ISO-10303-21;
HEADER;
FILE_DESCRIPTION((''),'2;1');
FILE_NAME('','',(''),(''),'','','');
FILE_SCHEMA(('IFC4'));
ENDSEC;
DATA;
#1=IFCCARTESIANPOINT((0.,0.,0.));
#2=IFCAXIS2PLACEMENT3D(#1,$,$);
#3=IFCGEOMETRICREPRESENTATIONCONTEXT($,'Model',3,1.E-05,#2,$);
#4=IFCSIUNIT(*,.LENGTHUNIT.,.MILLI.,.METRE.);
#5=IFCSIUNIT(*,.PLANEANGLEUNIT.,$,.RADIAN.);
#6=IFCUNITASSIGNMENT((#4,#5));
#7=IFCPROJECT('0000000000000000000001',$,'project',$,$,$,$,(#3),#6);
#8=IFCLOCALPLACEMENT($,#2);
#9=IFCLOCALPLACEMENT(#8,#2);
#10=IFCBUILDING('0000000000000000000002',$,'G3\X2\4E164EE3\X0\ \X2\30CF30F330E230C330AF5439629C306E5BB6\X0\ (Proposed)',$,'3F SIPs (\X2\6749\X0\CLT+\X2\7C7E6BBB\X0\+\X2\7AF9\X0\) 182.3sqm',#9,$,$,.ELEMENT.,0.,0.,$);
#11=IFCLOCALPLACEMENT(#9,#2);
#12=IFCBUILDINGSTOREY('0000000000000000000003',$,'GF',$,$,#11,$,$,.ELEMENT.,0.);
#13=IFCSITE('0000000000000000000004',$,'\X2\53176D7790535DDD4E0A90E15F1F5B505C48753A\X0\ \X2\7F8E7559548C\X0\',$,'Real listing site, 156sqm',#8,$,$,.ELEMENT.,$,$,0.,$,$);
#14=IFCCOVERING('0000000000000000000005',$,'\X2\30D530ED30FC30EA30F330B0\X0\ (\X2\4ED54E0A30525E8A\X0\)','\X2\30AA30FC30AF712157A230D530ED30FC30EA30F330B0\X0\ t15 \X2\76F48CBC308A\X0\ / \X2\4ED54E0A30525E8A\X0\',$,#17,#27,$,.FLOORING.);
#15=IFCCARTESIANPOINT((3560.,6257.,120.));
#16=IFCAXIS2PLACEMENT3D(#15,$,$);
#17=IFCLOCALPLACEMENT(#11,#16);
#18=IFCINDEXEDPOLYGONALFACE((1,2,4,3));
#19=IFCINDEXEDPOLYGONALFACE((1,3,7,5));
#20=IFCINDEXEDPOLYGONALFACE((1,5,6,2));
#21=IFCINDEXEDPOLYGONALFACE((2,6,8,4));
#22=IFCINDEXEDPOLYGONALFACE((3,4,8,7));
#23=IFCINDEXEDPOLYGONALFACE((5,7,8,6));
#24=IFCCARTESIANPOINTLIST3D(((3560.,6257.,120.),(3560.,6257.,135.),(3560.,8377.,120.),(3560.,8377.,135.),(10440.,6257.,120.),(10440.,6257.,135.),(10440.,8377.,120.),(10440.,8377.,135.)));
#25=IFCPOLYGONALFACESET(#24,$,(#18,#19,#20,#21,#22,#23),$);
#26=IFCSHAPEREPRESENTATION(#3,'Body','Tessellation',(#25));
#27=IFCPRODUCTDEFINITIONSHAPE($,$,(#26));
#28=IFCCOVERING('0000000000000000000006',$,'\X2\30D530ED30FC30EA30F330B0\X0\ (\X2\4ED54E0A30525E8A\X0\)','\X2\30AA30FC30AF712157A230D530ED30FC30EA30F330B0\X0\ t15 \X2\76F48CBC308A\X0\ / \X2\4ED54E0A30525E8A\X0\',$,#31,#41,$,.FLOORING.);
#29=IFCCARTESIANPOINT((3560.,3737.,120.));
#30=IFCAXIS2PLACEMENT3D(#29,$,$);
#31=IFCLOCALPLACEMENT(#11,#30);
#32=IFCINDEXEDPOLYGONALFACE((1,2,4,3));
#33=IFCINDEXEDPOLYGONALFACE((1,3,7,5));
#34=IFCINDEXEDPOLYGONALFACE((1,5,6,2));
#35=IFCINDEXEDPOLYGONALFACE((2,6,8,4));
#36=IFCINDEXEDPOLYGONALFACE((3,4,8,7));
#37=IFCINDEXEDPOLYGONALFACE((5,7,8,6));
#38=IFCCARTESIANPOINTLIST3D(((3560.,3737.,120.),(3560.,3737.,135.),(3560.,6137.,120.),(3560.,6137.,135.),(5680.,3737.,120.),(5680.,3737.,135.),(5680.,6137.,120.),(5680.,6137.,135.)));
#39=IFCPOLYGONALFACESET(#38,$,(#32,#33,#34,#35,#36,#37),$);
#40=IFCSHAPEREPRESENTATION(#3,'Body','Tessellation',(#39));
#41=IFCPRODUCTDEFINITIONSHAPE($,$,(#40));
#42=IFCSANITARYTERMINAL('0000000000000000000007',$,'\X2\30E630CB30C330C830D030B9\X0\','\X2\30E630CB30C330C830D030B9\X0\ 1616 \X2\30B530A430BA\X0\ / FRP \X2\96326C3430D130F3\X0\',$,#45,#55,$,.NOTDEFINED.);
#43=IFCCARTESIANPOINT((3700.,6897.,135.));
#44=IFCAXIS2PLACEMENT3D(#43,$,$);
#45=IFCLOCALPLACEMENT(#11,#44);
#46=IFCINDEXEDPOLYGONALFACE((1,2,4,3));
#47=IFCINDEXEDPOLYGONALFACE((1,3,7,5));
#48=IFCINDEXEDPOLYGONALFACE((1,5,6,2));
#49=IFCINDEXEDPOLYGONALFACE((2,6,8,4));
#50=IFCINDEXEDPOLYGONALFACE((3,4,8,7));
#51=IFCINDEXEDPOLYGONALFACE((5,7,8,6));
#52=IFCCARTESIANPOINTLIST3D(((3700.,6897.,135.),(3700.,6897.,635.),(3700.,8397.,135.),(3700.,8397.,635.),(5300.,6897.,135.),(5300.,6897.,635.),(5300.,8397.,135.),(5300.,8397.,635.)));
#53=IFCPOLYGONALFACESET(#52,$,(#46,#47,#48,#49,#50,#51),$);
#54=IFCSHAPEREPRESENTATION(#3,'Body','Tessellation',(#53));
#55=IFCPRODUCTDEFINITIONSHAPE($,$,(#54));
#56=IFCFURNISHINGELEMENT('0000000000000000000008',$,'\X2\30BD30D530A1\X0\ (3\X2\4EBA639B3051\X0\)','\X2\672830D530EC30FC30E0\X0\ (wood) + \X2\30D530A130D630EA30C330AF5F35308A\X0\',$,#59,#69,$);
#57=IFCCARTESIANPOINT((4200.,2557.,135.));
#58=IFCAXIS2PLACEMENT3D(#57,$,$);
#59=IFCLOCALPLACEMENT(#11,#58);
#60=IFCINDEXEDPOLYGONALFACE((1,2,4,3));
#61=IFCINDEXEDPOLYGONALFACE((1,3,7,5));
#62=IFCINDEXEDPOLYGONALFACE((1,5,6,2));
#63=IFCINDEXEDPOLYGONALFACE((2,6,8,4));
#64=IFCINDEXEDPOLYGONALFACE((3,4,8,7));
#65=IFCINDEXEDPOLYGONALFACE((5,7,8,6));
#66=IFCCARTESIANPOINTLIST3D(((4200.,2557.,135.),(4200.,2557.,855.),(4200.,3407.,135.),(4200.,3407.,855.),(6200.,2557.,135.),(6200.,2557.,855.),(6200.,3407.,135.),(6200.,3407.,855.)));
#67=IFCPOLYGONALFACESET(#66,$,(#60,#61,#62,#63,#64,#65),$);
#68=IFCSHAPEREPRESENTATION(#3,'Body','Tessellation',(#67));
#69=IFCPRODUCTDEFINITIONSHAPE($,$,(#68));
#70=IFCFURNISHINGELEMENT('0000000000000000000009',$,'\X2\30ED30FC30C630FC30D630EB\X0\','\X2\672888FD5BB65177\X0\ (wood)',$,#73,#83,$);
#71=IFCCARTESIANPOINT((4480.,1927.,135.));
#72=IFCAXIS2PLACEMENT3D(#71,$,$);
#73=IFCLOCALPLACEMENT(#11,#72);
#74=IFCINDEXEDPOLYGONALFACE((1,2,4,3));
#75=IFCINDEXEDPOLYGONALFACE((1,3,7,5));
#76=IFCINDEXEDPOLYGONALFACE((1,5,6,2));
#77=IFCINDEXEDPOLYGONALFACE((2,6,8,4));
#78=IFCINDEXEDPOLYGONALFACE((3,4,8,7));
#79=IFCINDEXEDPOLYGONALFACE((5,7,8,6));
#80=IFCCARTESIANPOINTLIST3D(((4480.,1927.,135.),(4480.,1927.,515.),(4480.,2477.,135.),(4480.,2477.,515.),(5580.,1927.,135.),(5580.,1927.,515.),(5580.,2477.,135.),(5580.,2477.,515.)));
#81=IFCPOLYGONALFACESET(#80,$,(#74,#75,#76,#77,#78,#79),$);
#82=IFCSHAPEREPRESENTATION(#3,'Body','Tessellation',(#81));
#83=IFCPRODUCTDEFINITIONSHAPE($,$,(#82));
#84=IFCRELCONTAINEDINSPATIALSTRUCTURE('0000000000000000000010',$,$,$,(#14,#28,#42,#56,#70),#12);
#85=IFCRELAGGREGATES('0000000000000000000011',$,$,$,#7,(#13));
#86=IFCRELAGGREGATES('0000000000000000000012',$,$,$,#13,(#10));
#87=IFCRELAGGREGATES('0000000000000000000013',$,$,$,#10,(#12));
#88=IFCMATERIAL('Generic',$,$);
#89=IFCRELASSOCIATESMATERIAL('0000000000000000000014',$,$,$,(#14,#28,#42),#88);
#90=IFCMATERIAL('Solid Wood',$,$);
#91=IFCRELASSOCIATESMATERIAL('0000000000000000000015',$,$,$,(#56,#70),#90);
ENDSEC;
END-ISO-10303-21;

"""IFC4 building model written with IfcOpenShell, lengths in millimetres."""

from ifc_helpers import new_model, si_unit, frame, frame_2d, origin, place, context, project, spatial, rectangle, extrude, material, element, save


model = new_model("IFC4")

# Units and contexts
model_context = context("Model", 3, precision=1e-05, world=origin())
ifc_project = project(units=[si_unit("LENGTHUNIT", "METRE", prefix="MILLI"), si_unit("PLANEANGLEUNIT", "RADIAN")], contexts=[model_context])

# Site, building, storey
site_placement = place(None, origin())
site = spatial("IfcSite", under=ifc_project, at=site_placement, Name="北海道川上郡弟子屈町 美留和", ObjectType="Real listing site, 156sqm", CompositionType="ELEMENT", RefElevation=0.0)
building_placement = place(site_placement, origin())
building = spatial("IfcBuilding", under=site, at=building_placement, Name="G3世代 ハンモック吹抜の家 (Proposed)", ObjectType="3F SIPs (杉CLT+籾殻+竹) 182.3sqm", CompositionType="ELEMENT", ElevationOfRefHeight=0.0, ElevationOfTerrain=0.0)
storey_placement = place(building_placement, origin())
storey = spatial("IfcBuildingStorey", under=building, at=storey_placement, Name="GF", CompositionType="ELEMENT", Elevation=0.0)

# Shared definitions
ifc_material_1 = material(Name="Solid Wood")

# Coverings
ifc_material_2 = material(Name="Generic")
covering_1_placement = place(storey_placement, frame((3560.0, 6257.0, 120.0)))
element("IfcCovering", 1, at=covering_1_placement, inside=storey, material=ifc_material_2, Name="フローリング (仕上げ床)", Description="オーク無垢フローリング t15 直貼り / 仕上げ床", PredefinedType="FLOORING", context=model_context, shape_type="SweptSolid", body=[
    extrude(rectangle(XDim=6880.0, YDim=2120.0, at=frame_2d((3440.0, 1060.0))), frame((3560.0, 6257.0, 120.0)), (0.0, 0.0, 1.0), 15.0),
])
covering_2_placement = place(storey_placement, frame((3560.0, 3737.0, 120.0)))
element("IfcCovering", 2, at=covering_2_placement, inside=storey, material=ifc_material_2, Name="フローリング (仕上げ床)", Description="オーク無垢フローリング t15 直貼り / 仕上げ床", PredefinedType="FLOORING", context=model_context, shape_type="SweptSolid", body=[
    extrude(rectangle(XDim=2120.0, YDim=2400.0, at=frame_2d((1060.0, 1200.0))), frame((3560.0, 3737.0, 120.0)), (0.0, 0.0, 1.0), 15.0),
])

# Sanitary terminal
sanitary_terminal_placement = place(storey_placement, frame((3700.0, 6897.0, 135.0)))
element("IfcSanitaryTerminal", 3, at=sanitary_terminal_placement, inside=storey, material=ifc_material_2, Name="ユニットバス", Description="ユニットバス 1616 サイズ / FRP 防水パン", PredefinedType="NOTDEFINED", context=model_context, shape_type="SweptSolid", body=[
    extrude(rectangle(XDim=1600.0, YDim=1500.0, at=frame_2d((800.0, 750.0))), frame((3700.0, 6897.0, 135.0)), (0.0, 0.0, 1.0), 500.0),
])

# Furnishing elements
furnishing_1_placement = place(storey_placement, frame((4200.0, 2557.0, 135.0)))
element("IfcFurnishingElement", 4, at=furnishing_1_placement, inside=storey, material=ifc_material_1, Name="ソファ (3人掛け)", Description="木フレーム (wood) + ファブリック張り", context=model_context, shape_type="SweptSolid", body=[
    extrude(rectangle(XDim=2000.0, YDim=850.0, at=frame_2d((1000.0, 425.0))), frame((4200.0, 2557.0, 135.0)), (0.0, 0.0, 1.0), 720.0),
])
furnishing_2_placement = place(storey_placement, frame((4480.0, 1927.0, 135.0)))
element("IfcFurnishingElement", 5, at=furnishing_2_placement, inside=storey, material=ifc_material_1, Name="ローテーブル", Description="木製家具 (wood)", context=model_context, shape_type="SweptSolid", body=[
    extrude(rectangle(XDim=1100.0, YDim=550.0, at=frame_2d((550.0, 275.0))), frame((4480.0, 1927.0, 135.0)), (0.0, 0.0, 1.0), 380.0),
])

save(model, "model.ifc")
